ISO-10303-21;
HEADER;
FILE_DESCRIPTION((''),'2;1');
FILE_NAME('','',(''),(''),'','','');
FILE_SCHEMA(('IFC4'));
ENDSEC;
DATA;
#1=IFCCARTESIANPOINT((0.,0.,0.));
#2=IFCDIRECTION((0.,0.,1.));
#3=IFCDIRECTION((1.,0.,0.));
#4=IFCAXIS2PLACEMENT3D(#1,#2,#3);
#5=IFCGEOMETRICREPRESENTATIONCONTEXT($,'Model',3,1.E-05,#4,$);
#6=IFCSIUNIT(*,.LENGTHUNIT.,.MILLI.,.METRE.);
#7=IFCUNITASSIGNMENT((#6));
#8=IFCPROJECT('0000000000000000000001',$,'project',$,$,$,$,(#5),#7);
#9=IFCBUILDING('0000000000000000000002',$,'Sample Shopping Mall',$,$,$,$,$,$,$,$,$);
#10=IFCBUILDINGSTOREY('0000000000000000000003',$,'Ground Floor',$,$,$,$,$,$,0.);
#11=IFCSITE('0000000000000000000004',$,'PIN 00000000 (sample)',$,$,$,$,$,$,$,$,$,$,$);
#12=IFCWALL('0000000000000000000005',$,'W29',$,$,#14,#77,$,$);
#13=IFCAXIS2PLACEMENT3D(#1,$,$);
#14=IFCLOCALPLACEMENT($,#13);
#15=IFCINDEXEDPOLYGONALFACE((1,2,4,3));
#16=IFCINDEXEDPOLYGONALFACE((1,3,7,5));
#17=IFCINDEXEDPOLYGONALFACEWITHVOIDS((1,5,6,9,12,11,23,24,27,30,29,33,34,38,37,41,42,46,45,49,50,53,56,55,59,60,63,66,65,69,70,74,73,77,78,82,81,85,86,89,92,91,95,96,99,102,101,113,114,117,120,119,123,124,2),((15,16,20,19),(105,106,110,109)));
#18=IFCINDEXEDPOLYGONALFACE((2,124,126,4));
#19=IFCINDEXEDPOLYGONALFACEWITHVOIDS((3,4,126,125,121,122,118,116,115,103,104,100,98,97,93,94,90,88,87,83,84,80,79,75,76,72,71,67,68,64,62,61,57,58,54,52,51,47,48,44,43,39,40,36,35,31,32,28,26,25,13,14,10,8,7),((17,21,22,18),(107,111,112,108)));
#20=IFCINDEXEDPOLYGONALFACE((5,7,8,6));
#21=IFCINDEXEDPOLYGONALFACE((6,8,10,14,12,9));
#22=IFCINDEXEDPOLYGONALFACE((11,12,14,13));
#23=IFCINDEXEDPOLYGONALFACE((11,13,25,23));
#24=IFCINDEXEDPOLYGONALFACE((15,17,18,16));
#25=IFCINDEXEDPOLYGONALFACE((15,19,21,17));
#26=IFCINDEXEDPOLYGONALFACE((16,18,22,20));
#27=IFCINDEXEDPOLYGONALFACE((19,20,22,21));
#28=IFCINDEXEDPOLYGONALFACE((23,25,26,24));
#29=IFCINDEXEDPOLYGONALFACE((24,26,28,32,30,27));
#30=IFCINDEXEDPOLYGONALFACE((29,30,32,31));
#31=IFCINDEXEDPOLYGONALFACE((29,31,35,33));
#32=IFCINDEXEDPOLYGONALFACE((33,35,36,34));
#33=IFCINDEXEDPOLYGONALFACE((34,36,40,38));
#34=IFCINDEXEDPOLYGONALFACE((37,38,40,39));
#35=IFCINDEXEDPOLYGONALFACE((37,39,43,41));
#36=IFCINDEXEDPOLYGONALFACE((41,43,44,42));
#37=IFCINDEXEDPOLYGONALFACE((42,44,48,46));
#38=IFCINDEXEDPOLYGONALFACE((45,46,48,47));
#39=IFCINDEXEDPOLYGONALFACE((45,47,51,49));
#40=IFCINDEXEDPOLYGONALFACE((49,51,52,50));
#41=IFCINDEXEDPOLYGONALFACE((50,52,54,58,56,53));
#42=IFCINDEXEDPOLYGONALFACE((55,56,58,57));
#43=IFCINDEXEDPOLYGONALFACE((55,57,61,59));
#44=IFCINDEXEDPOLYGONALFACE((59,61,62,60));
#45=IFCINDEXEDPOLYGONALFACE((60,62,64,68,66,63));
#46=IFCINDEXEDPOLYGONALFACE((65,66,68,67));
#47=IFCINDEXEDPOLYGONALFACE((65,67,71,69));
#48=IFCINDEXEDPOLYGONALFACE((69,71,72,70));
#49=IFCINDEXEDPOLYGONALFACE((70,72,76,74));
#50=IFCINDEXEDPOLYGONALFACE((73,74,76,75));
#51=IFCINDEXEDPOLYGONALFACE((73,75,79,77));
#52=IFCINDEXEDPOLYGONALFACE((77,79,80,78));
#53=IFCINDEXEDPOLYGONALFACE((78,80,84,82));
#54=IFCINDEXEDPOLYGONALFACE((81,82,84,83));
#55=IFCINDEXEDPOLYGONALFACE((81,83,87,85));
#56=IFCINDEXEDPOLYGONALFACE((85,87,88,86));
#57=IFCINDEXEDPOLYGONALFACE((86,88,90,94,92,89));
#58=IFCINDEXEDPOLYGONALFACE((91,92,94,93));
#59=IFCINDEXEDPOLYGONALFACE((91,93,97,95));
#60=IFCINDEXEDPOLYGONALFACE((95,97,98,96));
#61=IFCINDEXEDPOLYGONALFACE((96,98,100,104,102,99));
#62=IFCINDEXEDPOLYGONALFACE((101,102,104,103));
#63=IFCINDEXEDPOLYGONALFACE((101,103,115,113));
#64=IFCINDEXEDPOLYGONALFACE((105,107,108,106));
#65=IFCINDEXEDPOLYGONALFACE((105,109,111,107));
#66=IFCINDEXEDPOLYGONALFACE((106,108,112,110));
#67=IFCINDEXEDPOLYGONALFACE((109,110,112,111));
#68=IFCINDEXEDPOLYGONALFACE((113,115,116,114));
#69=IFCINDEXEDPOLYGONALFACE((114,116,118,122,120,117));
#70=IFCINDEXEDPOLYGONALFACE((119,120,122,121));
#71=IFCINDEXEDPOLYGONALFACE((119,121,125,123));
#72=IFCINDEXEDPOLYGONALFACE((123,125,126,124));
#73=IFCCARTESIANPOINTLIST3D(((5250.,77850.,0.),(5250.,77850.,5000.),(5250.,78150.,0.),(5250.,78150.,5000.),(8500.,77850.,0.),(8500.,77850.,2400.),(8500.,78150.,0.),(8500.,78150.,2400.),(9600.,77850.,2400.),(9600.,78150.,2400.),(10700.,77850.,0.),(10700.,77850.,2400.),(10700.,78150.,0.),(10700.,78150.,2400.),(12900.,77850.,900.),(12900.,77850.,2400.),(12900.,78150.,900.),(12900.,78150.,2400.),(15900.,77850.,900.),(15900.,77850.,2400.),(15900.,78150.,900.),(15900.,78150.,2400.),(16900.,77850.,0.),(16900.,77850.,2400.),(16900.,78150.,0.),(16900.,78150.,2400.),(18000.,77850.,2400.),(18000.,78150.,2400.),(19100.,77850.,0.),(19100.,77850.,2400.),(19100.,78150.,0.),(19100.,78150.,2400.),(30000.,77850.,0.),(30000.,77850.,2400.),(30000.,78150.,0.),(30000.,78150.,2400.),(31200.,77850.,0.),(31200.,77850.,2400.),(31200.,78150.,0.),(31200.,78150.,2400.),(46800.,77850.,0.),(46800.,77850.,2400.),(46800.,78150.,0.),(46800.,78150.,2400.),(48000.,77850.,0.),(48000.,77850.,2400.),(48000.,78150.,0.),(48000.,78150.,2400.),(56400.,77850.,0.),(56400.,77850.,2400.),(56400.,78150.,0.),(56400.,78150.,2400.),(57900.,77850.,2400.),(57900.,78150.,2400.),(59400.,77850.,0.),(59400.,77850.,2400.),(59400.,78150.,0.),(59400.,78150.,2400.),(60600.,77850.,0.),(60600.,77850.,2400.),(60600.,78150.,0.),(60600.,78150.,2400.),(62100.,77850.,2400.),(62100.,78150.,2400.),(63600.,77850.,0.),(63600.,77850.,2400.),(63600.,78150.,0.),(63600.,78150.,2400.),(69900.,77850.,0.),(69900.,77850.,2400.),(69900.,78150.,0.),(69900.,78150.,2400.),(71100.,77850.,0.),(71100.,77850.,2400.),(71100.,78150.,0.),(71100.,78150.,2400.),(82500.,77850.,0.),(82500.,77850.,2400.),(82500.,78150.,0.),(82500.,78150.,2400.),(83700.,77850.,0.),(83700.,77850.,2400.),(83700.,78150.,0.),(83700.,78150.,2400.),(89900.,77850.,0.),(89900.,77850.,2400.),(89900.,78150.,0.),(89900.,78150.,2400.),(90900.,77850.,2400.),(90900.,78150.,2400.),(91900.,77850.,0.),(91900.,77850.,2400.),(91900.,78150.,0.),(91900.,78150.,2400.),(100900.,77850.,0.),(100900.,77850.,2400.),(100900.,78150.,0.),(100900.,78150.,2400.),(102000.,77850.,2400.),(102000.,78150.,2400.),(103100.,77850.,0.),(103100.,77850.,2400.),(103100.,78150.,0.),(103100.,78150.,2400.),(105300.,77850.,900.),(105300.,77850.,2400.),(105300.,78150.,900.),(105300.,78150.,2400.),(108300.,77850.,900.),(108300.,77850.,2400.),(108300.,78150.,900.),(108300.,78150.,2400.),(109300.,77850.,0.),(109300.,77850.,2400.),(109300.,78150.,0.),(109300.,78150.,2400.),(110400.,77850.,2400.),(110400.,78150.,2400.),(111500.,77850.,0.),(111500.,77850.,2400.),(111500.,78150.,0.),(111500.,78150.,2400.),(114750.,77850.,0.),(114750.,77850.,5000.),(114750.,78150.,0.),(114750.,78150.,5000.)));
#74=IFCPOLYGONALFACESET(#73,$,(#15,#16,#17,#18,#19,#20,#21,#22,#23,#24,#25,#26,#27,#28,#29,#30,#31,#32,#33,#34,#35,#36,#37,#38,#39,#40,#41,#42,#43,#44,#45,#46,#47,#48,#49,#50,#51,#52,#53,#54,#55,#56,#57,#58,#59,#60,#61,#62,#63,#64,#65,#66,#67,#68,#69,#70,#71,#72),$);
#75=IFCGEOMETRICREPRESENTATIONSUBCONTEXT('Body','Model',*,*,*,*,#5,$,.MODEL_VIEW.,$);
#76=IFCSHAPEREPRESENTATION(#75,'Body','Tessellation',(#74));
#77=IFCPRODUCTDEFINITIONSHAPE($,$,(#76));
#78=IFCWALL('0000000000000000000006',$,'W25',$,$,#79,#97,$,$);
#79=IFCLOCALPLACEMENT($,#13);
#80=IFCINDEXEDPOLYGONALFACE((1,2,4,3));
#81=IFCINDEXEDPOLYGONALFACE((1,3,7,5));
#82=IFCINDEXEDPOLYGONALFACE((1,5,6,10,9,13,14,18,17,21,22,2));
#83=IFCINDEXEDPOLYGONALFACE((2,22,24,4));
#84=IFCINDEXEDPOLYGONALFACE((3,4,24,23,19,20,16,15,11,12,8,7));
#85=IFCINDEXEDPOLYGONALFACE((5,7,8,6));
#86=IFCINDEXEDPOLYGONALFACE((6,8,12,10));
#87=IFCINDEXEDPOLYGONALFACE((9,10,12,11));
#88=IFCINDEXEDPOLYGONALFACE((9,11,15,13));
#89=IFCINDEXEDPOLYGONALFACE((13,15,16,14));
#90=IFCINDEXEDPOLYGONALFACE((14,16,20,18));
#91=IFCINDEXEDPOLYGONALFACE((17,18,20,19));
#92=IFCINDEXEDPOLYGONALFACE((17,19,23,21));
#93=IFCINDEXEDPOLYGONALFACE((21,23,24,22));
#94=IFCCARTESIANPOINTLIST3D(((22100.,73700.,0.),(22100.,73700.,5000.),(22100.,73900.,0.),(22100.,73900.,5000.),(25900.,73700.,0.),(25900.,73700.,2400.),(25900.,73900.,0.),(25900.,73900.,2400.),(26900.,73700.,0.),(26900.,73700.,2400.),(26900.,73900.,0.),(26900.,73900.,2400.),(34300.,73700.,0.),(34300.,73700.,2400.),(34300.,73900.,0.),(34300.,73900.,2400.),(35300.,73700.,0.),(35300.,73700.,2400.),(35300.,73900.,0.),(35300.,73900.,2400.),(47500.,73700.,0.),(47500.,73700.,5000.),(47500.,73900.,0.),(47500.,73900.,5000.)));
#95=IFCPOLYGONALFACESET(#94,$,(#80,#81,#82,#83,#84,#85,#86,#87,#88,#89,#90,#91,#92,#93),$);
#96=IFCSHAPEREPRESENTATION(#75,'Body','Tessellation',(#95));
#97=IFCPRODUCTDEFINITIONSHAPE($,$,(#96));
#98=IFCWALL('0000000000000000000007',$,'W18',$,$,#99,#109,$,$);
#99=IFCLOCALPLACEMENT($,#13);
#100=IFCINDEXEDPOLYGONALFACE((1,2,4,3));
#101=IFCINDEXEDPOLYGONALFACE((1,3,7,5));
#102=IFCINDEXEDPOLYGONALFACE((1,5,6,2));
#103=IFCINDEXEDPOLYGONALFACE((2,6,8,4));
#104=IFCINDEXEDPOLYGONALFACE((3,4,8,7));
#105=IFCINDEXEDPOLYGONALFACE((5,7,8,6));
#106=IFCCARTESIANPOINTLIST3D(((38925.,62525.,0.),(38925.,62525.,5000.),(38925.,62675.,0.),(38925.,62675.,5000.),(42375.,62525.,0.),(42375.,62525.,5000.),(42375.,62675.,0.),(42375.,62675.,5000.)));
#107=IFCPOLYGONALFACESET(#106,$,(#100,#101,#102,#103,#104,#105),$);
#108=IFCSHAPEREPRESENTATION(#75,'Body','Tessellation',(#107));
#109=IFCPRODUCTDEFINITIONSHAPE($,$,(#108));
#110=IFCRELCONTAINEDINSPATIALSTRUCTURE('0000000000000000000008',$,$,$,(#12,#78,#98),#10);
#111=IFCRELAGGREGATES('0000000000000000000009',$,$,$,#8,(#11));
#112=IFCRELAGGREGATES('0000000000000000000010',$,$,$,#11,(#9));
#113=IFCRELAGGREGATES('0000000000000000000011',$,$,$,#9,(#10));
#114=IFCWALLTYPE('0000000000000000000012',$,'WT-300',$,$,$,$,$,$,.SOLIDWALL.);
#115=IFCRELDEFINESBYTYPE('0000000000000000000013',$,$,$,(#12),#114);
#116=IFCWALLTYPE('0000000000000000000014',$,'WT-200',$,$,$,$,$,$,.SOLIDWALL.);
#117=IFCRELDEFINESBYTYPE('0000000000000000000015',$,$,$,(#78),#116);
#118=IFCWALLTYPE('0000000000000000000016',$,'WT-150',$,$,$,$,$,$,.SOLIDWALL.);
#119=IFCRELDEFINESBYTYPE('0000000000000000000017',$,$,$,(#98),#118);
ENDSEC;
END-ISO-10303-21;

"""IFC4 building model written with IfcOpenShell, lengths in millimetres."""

from ifc_helpers import new_model, si_unit, frame, origin_with_axes, place, context, subcontext, project, spatial, indexed_curve, outline, extrude, type_object, element, save


model = new_model("IFC4")

# Units and contexts
model_context = context("Model", 3, precision=1e-05, world=origin_with_axes())
body_context = subcontext(model_context, "Body", "Model", "MODEL_VIEW")
ifc_project = project(units=[si_unit("LENGTHUNIT", "METRE", prefix="MILLI")], contexts=[model_context])

# Site, building, storey
site = spatial("IfcSite", under=ifc_project, Name="PIN 00000000 (sample)")
building = spatial("IfcBuilding", under=site, Name="Sample Shopping Mall")
storey = spatial("IfcBuildingStorey", under=building, Name="Ground Floor", Elevation=0.0)

# Walls, openings
wall_type_1 = type_object("IfcWallType", Name="WT-300", PredefinedType="SOLIDWALL")
wall_1_placement = place(None, frame((5250.0, 77850.0, 0.0), z_axis=(0.0, 0.0, 1.0), x_axis=(1.0, 0.0, 0.0)))
wall_1 = element("IfcWall", 1, at=wall_1_placement, inside=storey, type_object=wall_type_1, Name="W29", context=body_context, shape_type="SweptSolid", body=[
    extrude(outline(indexed_curve([(0.0, 0.0), (0.0, 300.0), (109500.0, 300.0), (109500.0, 0.0), (0.0, 0.0)], self_intersect=False)), origin_with_axes(), (0.0, 0.0, 1.0), 5000.0),
])
opening_1_placement = place(wall_1_placement, frame((3250.0, -100.0, 0.0), z_axis=(0.0, 0.0, 1.0), x_axis=(1.0, 0.0, 0.0)))
element("IfcOpeningElement", 2, at=opening_1_placement, cuts=wall_1, context=body_context, shape_type="SweptSolid", body=[
    extrude(outline(indexed_curve([(0.0, 0.0), (0.0, 500.0), (1100.0, 500.0), (1100.0, 0.0), (0.0, 0.0)], self_intersect=False)), origin_with_axes(), (0.0, 0.0, 1.0), 2400.0),
])
opening_2_placement = place(wall_1_placement, frame((4350.0, -100.0, 0.0), z_axis=(0.0, 0.0, 1.0), x_axis=(1.0, 0.0, 0.0)))
element("IfcOpeningElement", 3, at=opening_2_placement, cuts=wall_1, context=body_context, shape_type="SweptSolid", body=[
    extrude(outline(indexed_curve([(0.0, 0.0), (0.0, 500.0), (1100.0, 500.0), (1100.0, 0.0), (0.0, 0.0)], self_intersect=False)), origin_with_axes(), (0.0, 0.0, 1.0), 2400.0),
])
opening_3_placement = place(wall_1_placement, frame((11650.0, -100.0, 0.0), z_axis=(0.0, 0.0, 1.0), x_axis=(1.0, 0.0, 0.0)))
element("IfcOpeningElement", 4, at=opening_3_placement, cuts=wall_1, context=body_context, shape_type="SweptSolid", body=[
    extrude(outline(indexed_curve([(0.0, 0.0), (0.0, 500.0), (1100.0, 500.0), (1100.0, 0.0), (0.0, 0.0)], self_intersect=False)), origin_with_axes(), (0.0, 0.0, 1.0), 2400.0),
])
opening_4_placement = place(wall_1_placement, frame((12750.0, -100.0, 0.0), z_axis=(0.0, 0.0, 1.0), x_axis=(1.0, 0.0, 0.0)))
element("IfcOpeningElement", 5, at=opening_4_placement, cuts=wall_1, context=body_context, shape_type="SweptSolid", body=[
    extrude(outline(indexed_curve([(0.0, 0.0), (0.0, 500.0), (1100.0, 500.0), (1100.0, 0.0), (0.0, 0.0)], self_intersect=False)), origin_with_axes(), (0.0, 0.0, 1.0), 2400.0),
])
opening_5_placement = place(wall_1_placement, frame((95650.0, -100.0, 0.0), z_axis=(0.0, 0.0, 1.0), x_axis=(1.0, 0.0, 0.0)))
element("IfcOpeningElement", 6, at=opening_5_placement, cuts=wall_1, context=body_context, shape_type="SweptSolid", body=[
    extrude(outline(indexed_curve([(0.0, 0.0), (0.0, 500.0), (1100.0, 500.0), (1100.0, 0.0), (0.0, 0.0)], self_intersect=False)), origin_with_axes(), (0.0, 0.0, 1.0), 2400.0),
])
opening_6_placement = place(wall_1_placement, frame((96750.0, -100.0, 0.0), z_axis=(0.0, 0.0, 1.0), x_axis=(1.0, 0.0, 0.0)))
element("IfcOpeningElement", 7, at=opening_6_placement, cuts=wall_1, context=body_context, shape_type="SweptSolid", body=[
    extrude(outline(indexed_curve([(0.0, 0.0), (0.0, 500.0), (1100.0, 500.0), (1100.0, 0.0), (0.0, 0.0)], self_intersect=False)), origin_with_axes(), (0.0, 0.0, 1.0), 2400.0),
])
opening_7_placement = place(wall_1_placement, frame((104050.0, -100.0, 0.0), z_axis=(0.0, 0.0, 1.0), x_axis=(1.0, 0.0, 0.0)))
element("IfcOpeningElement", 8, at=opening_7_placement, cuts=wall_1, context=body_context, shape_type="SweptSolid", body=[
    extrude(outline(indexed_curve([(0.0, 0.0), (0.0, 500.0), (1100.0, 500.0), (1100.0, 0.0), (0.0, 0.0)], self_intersect=False)), origin_with_axes(), (0.0, 0.0, 1.0), 2400.0),
])
opening_8_placement = place(wall_1_placement, frame((105150.0, -100.0, 0.0), z_axis=(0.0, 0.0, 1.0), x_axis=(1.0, 0.0, 0.0)))
element("IfcOpeningElement", 9, at=opening_8_placement, cuts=wall_1, context=body_context, shape_type="SweptSolid", body=[
    extrude(outline(indexed_curve([(0.0, 0.0), (0.0, 500.0), (1100.0, 500.0), (1100.0, 0.0), (0.0, 0.0)], self_intersect=False)), origin_with_axes(), (0.0, 0.0, 1.0), 2400.0),
])
opening_9_placement = place(wall_1_placement, frame((24750.0, -100.0, 0.0), z_axis=(0.0, 0.0, 1.0), x_axis=(1.0, 0.0, 0.0)))
element("IfcOpeningElement", 10, at=opening_9_placement, cuts=wall_1, context=body_context, shape_type="SweptSolid", body=[
    extrude(outline(indexed_curve([(0.0, 0.0), (0.0, 500.0), (1200.0, 500.0), (1200.0, 0.0), (0.0, 0.0)], self_intersect=False)), origin_with_axes(), (0.0, 0.0, 1.0), 2400.0),
])
opening_10_placement = place(wall_1_placement, frame((41550.0, -100.0, 0.0), z_axis=(0.0, 0.0, 1.0), x_axis=(1.0, 0.0, 0.0)))
element("IfcOpeningElement", 11, at=opening_10_placement, cuts=wall_1, context=body_context, shape_type="SweptSolid", body=[
    extrude(outline(indexed_curve([(0.0, 0.0), (0.0, 500.0), (1200.0, 500.0), (1200.0, 0.0), (0.0, 0.0)], self_intersect=False)), origin_with_axes(), (0.0, 0.0, 1.0), 2400.0),
])
opening_11_placement = place(wall_1_placement, frame((64650.0, -100.0, 0.0), z_axis=(0.0, 0.0, 1.0), x_axis=(1.0, 0.0, 0.0)))
element("IfcOpeningElement", 12, at=opening_11_placement, cuts=wall_1, context=body_context, shape_type="SweptSolid", body=[
    extrude(outline(indexed_curve([(0.0, 0.0), (0.0, 500.0), (1200.0, 500.0), (1200.0, 0.0), (0.0, 0.0)], self_intersect=False)), origin_with_axes(), (0.0, 0.0, 1.0), 2400.0),
])
opening_12_placement = place(wall_1_placement, frame((77250.0, -100.0, 0.0), z_axis=(0.0, 0.0, 1.0), x_axis=(1.0, 0.0, 0.0)))
element("IfcOpeningElement", 13, at=opening_12_placement, cuts=wall_1, context=body_context, shape_type="SweptSolid", body=[
    extrude(outline(indexed_curve([(0.0, 0.0), (0.0, 500.0), (1200.0, 500.0), (1200.0, 0.0), (0.0, 0.0)], self_intersect=False)), origin_with_axes(), (0.0, 0.0, 1.0), 2400.0),
])
opening_13_placement = place(wall_1_placement, frame((51150.0, -100.0, 0.0), z_axis=(0.0, 0.0, 1.0), x_axis=(1.0, 0.0, 0.0)))
element("IfcOpeningElement", 14, at=opening_13_placement, cuts=wall_1, context=body_context, shape_type="SweptSolid", body=[
    extrude(outline(indexed_curve([(0.0, 0.0), (0.0, 500.0), (1500.0, 500.0), (1500.0, 0.0), (0.0, 0.0)], self_intersect=False)), origin_with_axes(), (0.0, 0.0, 1.0), 2400.0),
])
opening_14_placement = place(wall_1_placement, frame((52650.0, -100.0, 0.0), z_axis=(0.0, 0.0, 1.0), x_axis=(1.0, 0.0, 0.0)))
element("IfcOpeningElement", 15, at=opening_14_placement, cuts=wall_1, context=body_context, shape_type="SweptSolid", body=[
    extrude(outline(indexed_curve([(0.0, 0.0), (0.0, 500.0), (1500.0, 500.0), (1500.0, 0.0), (0.0, 0.0)], self_intersect=False)), origin_with_axes(), (0.0, 0.0, 1.0), 2400.0),
])
opening_15_placement = place(wall_1_placement, frame((55350.0, -100.0, 0.0), z_axis=(0.0, 0.0, 1.0), x_axis=(1.0, 0.0, 0.0)))
element("IfcOpeningElement", 16, at=opening_15_placement, cuts=wall_1, context=body_context, shape_type="SweptSolid", body=[
    extrude(outline(indexed_curve([(0.0, 0.0), (0.0, 500.0), (1500.0, 500.0), (1500.0, 0.0), (0.0, 0.0)], self_intersect=False)), origin_with_axes(), (0.0, 0.0, 1.0), 2400.0),
])
opening_16_placement = place(wall_1_placement, frame((56850.0, -100.0, 0.0), z_axis=(0.0, 0.0, 1.0), x_axis=(1.0, 0.0, 0.0)))
element("IfcOpeningElement", 17, at=opening_16_placement, cuts=wall_1, context=body_context, shape_type="SweptSolid", body=[
    extrude(outline(indexed_curve([(0.0, 0.0), (0.0, 500.0), (1500.0, 500.0), (1500.0, 0.0), (0.0, 0.0)], self_intersect=False)), origin_with_axes(), (0.0, 0.0, 1.0), 2400.0),
])
opening_17_placement = place(wall_1_placement, frame((84650.0, -100.0, 0.0), z_axis=(0.0, 0.0, 1.0), x_axis=(1.0, 0.0, 0.0)))
element("IfcOpeningElement", 18, at=opening_17_placement, cuts=wall_1, context=body_context, shape_type="SweptSolid", body=[
    extrude(outline(indexed_curve([(0.0, 0.0), (0.0, 500.0), (1000.0, 500.0), (1000.0, 0.0), (0.0, 0.0)], self_intersect=False)), origin_with_axes(), (0.0, 0.0, 1.0), 2400.0),
])
opening_18_placement = place(wall_1_placement, frame((85650.0, -100.0, 0.0), z_axis=(0.0, 0.0, 1.0), x_axis=(1.0, 0.0, 0.0)))
element("IfcOpeningElement", 19, at=opening_18_placement, cuts=wall_1, context=body_context, shape_type="SweptSolid", body=[
    extrude(outline(indexed_curve([(0.0, 0.0), (0.0, 500.0), (1000.0, 500.0), (1000.0, 0.0), (0.0, 0.0)], self_intersect=False)), origin_with_axes(), (0.0, 0.0, 1.0), 2400.0),
])
opening_19_placement = place(wall_1_placement, frame((7650.0, -100.0, 900.0), z_axis=(0.0, 0.0, 1.0), x_axis=(1.0, 0.0, 0.0)))
element("IfcOpeningElement", 20, at=opening_19_placement, cuts=wall_1, context=body_context, shape_type="SweptSolid", body=[
    extrude(outline(indexed_curve([(0.0, 0.0), (0.0, 500.0), (3000.0, 500.0), (3000.0, 0.0), (0.0, 0.0)], self_intersect=False)), origin_with_axes(), (0.0, 0.0, 1.0), 1500.0),
])
opening_20_placement = place(wall_1_placement, frame((100050.0, -100.0, 900.0), z_axis=(0.0, 0.0, 1.0), x_axis=(1.0, 0.0, 0.0)))
element("IfcOpeningElement", 21, at=opening_20_placement, cuts=wall_1, context=body_context, shape_type="SweptSolid", body=[
    extrude(outline(indexed_curve([(0.0, 0.0), (0.0, 500.0), (3000.0, 500.0), (3000.0, 0.0), (0.0, 0.0)], self_intersect=False)), origin_with_axes(), (0.0, 0.0, 1.0), 1500.0),
])
wall_type_2 = type_object("IfcWallType", Name="WT-200", PredefinedType="SOLIDWALL")
wall_2_placement = place(None, frame((22100.0, 73700.0, 0.0), z_axis=(0.0, 0.0, 1.0), x_axis=(1.0, 0.0, 0.0)))
wall_2 = element("IfcWall", 22, at=wall_2_placement, inside=storey, type_object=wall_type_2, Name="W25", context=body_context, shape_type="SweptSolid", body=[
    extrude(outline(indexed_curve([(0.0, 0.0), (0.0, 200.0), (25400.0, 200.0), (25400.0, 0.0), (0.0, 0.0)], self_intersect=False)), origin_with_axes(), (0.0, 0.0, 1.0), 5000.0),
])
opening_21_placement = place(wall_2_placement, frame((3800.0, -100.0, 0.0), z_axis=(0.0, 0.0, 1.0), x_axis=(1.0, 0.0, 0.0)))
element("IfcOpeningElement", 23, at=opening_21_placement, cuts=wall_2, context=body_context, shape_type="SweptSolid", body=[
    extrude(outline(indexed_curve([(0.0, 0.0), (0.0, 400.0), (1000.0, 400.0), (1000.0, 0.0), (0.0, 0.0)], self_intersect=False)), origin_with_axes(), (0.0, 0.0, 1.0), 2400.0),
])
opening_22_placement = place(wall_2_placement, frame((12200.0, -100.0, 0.0), z_axis=(0.0, 0.0, 1.0), x_axis=(1.0, 0.0, 0.0)))
element("IfcOpeningElement", 24, at=opening_22_placement, cuts=wall_2, context=body_context, shape_type="SweptSolid", body=[
    extrude(outline(indexed_curve([(0.0, 0.0), (0.0, 400.0), (1000.0, 400.0), (1000.0, 0.0), (0.0, 0.0)], self_intersect=False)), origin_with_axes(), (0.0, 0.0, 1.0), 2400.0),
])

# Wall
wall_type_3 = type_object("IfcWallType", Name="WT-150", PredefinedType="SOLIDWALL")
for number, where, z_axis, x_axis, name in (
    (25, (38925.0, 62525.0, 0.0), (0.0, 0.0, 1.0), (1.0, 0.0, 0.0), "W18"),
):
    element("IfcWall", number, at=place(None, frame(where, z_axis=z_axis, x_axis=x_axis)), inside=storey, type_object=wall_type_3, Name=name, context=body_context, shape_type="SweptSolid", body=[
        extrude(outline(indexed_curve([(0.0, 0.0), (0.0, 150.0), (3450.0, 150.0), (3450.0, 0.0), (0.0, 0.0)], self_intersect=False)), origin_with_axes(), (0.0, 0.0, 1.0), 5000.0),
    ])

save(model, "model.ifc")
